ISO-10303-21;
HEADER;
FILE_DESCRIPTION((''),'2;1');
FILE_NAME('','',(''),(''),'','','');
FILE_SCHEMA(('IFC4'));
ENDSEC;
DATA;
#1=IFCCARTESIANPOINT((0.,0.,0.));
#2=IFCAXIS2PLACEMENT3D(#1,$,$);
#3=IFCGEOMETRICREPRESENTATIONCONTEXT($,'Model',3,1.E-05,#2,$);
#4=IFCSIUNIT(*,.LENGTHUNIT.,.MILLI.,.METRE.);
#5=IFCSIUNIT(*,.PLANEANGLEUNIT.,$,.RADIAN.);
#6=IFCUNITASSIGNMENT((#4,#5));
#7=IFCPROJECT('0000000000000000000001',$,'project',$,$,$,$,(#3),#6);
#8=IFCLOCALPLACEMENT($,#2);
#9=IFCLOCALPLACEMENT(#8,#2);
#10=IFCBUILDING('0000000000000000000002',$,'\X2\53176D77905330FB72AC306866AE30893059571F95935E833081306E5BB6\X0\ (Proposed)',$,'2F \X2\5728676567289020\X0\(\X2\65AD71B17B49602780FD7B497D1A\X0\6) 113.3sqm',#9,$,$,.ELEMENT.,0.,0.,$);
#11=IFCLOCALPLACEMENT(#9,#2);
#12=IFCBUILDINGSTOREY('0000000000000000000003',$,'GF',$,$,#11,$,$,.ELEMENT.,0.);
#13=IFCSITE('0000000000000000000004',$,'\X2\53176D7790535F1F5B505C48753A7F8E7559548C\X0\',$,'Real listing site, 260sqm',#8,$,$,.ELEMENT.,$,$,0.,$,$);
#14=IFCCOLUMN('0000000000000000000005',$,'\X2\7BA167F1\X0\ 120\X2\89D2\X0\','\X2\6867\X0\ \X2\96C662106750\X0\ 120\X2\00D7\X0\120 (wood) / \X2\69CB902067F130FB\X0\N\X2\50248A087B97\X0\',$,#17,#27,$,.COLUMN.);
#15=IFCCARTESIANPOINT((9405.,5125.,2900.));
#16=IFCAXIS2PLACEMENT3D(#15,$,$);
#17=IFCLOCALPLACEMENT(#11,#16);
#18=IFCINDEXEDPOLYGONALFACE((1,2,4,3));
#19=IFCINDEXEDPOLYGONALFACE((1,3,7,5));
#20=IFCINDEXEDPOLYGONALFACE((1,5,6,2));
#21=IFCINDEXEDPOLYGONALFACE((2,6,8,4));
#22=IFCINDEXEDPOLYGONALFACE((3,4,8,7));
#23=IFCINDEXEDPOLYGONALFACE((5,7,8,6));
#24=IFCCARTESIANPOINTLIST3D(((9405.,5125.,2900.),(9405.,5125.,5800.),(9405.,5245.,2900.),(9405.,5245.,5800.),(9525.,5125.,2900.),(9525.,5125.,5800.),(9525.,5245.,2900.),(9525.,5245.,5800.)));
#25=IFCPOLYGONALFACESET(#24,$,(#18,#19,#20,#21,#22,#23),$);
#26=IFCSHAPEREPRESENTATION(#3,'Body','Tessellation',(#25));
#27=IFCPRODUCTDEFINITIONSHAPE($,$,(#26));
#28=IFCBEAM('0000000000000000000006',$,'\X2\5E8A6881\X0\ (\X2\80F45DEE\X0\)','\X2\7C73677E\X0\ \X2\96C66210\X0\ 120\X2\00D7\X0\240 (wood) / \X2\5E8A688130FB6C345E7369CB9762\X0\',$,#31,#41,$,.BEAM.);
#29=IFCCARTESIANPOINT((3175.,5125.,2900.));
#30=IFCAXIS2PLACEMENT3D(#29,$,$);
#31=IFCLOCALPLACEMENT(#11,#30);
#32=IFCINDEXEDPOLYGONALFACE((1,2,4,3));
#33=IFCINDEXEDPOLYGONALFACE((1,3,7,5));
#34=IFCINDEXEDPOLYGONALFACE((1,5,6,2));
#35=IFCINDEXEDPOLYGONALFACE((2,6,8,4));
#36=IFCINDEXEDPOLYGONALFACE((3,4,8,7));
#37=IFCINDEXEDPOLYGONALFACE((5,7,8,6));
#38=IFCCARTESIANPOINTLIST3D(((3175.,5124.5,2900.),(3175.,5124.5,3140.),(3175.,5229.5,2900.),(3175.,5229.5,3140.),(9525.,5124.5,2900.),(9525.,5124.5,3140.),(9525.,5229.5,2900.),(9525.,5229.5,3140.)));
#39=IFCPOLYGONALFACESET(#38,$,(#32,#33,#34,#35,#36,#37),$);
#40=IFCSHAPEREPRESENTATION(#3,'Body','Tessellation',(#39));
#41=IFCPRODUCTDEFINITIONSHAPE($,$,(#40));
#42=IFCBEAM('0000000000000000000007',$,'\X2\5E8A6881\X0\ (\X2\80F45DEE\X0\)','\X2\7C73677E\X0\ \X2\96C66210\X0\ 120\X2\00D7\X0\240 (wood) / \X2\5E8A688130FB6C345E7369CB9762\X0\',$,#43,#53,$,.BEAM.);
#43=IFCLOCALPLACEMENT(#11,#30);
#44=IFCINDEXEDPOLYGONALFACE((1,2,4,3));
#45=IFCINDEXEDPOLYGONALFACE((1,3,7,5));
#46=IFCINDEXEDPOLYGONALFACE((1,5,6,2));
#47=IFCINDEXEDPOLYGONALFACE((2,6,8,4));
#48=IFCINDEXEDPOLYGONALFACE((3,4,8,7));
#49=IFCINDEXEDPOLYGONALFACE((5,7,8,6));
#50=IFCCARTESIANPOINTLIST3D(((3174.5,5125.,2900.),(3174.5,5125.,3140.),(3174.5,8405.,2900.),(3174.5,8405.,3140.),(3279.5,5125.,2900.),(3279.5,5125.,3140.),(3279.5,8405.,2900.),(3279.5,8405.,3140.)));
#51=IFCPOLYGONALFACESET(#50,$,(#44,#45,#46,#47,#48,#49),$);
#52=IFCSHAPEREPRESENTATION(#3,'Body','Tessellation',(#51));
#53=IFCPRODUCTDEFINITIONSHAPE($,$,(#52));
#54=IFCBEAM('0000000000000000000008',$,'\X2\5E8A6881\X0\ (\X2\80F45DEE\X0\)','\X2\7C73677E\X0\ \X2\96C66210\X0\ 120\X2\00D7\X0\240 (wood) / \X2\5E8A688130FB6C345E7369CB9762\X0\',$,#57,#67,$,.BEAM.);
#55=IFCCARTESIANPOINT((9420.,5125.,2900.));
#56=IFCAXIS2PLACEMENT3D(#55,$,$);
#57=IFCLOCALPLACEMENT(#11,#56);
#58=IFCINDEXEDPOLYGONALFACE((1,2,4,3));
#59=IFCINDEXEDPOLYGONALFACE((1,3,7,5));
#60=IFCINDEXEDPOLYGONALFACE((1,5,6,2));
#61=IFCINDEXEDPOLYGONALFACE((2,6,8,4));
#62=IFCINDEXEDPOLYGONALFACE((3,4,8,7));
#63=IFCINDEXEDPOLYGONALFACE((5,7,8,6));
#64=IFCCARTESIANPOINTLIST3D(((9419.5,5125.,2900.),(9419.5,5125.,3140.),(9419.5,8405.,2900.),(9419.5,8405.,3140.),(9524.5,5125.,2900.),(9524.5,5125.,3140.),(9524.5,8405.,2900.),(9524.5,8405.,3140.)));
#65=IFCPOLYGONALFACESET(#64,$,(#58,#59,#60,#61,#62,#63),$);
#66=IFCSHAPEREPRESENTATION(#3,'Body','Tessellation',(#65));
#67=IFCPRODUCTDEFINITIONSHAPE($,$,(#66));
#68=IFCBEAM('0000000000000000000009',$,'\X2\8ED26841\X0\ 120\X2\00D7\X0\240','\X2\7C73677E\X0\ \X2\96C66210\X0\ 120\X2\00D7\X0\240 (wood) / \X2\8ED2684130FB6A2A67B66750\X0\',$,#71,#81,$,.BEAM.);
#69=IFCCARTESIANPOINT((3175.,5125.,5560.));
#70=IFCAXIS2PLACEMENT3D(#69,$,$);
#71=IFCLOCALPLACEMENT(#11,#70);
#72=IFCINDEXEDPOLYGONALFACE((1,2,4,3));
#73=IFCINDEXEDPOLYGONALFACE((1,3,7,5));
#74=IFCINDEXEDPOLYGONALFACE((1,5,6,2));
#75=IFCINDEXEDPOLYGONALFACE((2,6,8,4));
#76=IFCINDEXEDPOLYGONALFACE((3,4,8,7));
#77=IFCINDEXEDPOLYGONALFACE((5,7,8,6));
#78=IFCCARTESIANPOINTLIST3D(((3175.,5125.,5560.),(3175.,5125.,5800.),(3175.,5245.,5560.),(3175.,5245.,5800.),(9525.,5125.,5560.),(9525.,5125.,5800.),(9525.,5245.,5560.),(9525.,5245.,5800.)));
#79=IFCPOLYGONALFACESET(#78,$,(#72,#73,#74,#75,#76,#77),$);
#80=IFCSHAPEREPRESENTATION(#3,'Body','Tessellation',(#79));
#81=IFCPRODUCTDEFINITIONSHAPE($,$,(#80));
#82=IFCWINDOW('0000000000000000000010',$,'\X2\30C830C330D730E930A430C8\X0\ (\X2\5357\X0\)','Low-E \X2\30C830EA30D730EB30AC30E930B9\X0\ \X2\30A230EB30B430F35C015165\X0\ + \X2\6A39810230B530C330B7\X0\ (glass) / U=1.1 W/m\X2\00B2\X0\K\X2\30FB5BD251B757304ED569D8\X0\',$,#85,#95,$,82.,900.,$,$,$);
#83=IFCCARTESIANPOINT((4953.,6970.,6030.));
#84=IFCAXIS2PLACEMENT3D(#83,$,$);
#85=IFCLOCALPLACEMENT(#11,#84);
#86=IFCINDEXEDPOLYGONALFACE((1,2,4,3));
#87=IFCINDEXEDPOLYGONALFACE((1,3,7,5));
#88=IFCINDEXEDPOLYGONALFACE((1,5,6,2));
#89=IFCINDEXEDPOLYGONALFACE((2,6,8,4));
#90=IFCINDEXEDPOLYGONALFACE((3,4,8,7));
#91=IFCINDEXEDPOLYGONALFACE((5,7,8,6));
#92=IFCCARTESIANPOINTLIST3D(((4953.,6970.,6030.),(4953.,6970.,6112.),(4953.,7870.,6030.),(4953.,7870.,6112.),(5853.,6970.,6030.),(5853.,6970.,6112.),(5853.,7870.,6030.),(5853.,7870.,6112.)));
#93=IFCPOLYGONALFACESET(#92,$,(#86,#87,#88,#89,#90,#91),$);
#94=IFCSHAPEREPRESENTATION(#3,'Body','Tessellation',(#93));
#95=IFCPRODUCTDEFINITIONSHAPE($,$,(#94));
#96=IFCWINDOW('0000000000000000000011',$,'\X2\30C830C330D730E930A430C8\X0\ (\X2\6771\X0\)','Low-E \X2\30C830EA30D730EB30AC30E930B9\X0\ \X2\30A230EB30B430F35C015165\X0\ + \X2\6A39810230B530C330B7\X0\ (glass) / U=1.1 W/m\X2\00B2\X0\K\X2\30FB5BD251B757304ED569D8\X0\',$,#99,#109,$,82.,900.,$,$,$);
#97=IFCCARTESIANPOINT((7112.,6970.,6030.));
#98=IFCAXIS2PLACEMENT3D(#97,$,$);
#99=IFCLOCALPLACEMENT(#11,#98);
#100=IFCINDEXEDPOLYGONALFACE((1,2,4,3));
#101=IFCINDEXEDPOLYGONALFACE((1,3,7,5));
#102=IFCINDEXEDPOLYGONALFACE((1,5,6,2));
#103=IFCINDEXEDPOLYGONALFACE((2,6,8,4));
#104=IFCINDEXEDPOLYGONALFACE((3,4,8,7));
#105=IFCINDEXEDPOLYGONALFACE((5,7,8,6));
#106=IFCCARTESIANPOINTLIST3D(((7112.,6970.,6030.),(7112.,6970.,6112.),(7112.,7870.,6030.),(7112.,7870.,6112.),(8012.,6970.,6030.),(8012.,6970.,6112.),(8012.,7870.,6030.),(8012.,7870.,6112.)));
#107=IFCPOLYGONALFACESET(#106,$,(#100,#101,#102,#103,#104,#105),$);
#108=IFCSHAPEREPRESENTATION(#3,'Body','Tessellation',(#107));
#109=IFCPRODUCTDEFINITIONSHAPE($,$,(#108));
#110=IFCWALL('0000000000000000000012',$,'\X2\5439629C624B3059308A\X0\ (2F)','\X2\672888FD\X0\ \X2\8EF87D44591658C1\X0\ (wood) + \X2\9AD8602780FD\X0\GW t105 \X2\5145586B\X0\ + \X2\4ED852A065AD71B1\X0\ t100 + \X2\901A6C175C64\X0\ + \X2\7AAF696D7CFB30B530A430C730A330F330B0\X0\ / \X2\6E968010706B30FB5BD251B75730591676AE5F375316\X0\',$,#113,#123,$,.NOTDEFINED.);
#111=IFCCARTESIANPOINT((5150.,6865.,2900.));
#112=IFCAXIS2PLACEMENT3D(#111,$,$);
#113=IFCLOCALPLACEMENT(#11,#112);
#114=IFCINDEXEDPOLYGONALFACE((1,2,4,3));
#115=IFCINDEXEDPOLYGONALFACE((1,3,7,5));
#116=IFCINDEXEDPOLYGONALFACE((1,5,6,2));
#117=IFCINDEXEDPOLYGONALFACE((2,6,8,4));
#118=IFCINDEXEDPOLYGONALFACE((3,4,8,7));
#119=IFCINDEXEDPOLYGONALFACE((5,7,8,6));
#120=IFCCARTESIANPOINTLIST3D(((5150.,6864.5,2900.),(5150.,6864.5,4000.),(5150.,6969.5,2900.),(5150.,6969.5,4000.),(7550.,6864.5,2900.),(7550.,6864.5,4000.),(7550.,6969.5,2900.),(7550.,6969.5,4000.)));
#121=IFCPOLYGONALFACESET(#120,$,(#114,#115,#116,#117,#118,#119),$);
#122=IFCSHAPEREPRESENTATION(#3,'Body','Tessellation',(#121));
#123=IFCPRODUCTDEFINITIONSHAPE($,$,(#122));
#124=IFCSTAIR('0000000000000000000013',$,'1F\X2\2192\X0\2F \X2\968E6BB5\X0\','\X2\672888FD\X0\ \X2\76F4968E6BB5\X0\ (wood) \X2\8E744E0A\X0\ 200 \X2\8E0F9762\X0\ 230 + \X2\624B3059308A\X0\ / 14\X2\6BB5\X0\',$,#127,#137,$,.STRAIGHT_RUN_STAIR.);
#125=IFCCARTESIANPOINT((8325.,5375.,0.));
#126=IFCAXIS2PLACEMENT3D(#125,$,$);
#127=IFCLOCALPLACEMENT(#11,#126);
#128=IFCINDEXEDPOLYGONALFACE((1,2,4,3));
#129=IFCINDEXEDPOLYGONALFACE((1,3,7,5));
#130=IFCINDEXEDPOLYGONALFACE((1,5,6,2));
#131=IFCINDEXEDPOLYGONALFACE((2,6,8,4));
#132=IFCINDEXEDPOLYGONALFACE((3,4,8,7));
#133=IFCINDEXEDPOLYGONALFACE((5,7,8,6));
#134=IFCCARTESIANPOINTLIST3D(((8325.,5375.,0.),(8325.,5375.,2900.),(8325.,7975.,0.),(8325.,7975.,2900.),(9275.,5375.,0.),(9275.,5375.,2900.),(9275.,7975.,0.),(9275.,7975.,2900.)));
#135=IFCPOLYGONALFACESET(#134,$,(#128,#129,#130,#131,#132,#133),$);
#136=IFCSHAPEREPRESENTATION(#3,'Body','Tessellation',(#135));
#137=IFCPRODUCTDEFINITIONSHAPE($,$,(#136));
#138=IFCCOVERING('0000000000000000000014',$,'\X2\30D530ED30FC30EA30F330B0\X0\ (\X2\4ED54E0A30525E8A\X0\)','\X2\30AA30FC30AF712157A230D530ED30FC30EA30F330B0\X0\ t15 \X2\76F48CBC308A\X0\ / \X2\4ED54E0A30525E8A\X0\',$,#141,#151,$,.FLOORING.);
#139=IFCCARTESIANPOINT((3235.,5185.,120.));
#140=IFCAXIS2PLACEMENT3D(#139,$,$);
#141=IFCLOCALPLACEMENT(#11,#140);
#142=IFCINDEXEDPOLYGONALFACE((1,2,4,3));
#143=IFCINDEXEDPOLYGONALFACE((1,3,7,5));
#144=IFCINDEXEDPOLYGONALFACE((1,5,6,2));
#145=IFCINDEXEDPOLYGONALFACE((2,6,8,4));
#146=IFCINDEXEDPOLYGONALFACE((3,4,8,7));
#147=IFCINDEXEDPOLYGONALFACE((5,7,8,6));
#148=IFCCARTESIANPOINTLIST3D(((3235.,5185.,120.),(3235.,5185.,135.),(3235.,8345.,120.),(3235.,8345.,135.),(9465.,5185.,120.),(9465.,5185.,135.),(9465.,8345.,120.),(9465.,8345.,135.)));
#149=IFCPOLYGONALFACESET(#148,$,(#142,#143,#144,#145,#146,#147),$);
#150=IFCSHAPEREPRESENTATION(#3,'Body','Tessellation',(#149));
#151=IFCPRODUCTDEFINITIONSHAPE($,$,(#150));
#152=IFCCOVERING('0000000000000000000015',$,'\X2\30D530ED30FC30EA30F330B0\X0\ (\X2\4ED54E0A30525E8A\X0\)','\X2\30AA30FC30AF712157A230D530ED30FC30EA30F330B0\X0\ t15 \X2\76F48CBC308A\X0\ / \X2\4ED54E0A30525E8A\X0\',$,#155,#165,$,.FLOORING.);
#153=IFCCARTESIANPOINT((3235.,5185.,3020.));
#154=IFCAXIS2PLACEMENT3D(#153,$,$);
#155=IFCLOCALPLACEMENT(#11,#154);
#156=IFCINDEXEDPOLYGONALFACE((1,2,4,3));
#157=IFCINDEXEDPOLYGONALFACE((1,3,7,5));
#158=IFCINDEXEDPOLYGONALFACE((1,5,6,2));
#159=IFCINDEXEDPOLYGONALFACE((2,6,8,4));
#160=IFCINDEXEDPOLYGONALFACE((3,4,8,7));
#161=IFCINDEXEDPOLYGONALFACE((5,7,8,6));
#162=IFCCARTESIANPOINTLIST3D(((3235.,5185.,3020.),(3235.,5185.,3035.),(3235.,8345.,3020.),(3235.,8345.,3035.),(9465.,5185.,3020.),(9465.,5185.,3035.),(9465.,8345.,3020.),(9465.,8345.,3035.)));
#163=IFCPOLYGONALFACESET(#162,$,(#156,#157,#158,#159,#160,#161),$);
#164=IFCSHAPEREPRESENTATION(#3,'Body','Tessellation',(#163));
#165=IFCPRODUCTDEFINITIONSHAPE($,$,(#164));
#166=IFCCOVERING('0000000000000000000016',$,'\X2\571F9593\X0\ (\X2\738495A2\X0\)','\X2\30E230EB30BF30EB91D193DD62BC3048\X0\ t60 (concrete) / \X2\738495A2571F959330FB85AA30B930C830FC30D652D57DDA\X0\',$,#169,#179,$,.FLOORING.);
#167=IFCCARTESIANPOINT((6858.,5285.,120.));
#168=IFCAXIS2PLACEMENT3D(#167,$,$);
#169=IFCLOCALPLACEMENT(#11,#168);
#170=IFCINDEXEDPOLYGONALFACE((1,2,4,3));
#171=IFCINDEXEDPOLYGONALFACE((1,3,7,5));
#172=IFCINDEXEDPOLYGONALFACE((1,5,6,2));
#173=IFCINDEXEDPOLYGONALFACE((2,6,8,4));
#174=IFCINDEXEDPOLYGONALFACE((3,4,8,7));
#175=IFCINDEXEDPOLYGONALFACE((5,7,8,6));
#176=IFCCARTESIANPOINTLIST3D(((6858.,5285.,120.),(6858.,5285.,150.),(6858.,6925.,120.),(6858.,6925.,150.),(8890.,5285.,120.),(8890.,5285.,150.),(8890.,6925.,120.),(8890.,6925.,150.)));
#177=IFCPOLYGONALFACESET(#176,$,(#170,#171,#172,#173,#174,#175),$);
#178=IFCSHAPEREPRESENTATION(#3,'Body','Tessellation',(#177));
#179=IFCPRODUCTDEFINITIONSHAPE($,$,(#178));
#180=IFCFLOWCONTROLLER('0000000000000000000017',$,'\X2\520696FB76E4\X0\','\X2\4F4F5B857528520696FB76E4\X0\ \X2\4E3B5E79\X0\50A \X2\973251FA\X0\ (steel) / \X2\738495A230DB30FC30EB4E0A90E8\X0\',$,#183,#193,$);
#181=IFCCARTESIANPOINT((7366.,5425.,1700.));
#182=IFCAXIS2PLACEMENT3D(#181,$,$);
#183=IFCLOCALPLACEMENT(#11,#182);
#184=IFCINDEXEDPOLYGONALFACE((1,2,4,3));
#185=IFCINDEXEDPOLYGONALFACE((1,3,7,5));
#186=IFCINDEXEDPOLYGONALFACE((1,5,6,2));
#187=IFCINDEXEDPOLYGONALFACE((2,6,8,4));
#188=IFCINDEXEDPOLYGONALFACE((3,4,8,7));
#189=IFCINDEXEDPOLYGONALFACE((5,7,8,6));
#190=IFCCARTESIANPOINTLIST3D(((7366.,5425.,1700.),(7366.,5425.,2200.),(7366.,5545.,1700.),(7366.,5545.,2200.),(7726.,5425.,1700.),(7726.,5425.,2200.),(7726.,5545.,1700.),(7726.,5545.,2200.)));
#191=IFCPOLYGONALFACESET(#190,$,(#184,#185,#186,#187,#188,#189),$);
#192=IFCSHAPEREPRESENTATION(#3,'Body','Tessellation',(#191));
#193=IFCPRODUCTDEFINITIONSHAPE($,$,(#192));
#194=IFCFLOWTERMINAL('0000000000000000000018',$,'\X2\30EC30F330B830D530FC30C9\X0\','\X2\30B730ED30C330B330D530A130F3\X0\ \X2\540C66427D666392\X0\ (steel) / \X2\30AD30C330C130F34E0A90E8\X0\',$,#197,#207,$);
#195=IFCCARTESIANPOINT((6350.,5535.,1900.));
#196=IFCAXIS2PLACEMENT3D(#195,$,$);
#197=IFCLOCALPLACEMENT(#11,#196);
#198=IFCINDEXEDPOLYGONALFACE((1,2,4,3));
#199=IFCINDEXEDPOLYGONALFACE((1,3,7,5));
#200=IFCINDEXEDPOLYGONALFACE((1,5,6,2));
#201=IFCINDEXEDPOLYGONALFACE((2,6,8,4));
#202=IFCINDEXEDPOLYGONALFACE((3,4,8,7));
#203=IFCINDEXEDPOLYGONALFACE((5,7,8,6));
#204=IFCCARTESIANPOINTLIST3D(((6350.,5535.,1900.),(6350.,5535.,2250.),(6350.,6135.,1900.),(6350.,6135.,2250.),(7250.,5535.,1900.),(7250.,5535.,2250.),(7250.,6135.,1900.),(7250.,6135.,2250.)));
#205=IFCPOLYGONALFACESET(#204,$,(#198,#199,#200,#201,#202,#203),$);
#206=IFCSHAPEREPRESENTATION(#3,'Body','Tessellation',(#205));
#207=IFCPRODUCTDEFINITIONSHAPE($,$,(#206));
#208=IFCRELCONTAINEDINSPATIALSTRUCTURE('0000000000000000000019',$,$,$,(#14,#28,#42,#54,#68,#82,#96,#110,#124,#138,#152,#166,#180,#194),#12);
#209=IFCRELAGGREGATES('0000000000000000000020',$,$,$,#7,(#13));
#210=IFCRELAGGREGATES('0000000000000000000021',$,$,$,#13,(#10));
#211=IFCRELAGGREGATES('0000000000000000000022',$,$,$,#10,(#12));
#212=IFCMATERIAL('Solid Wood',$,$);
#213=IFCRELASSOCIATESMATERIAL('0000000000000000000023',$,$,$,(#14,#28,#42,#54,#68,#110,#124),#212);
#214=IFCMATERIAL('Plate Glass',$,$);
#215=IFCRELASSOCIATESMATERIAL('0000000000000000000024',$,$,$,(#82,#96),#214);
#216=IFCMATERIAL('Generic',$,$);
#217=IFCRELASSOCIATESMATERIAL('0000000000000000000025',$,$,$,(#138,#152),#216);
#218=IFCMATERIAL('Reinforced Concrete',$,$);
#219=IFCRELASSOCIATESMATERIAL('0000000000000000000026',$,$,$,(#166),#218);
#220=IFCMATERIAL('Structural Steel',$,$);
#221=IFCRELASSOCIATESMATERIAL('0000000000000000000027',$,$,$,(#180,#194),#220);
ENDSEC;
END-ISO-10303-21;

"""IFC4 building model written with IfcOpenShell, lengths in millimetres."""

from ifc_helpers import new_model, si_unit, frame, frame_2d, origin, place, context, project, spatial, rectangle, extrude, material, element, save


model = new_model("IFC4")

# Units and contexts
model_context = context("Model", 3, precision=1e-05, world=origin())
ifc_project = project(units=[si_unit("LENGTHUNIT", "METRE", prefix="MILLI"), si_unit("PLANEANGLEUNIT", "RADIAN")], contexts=[model_context])

# Site, building, storey
site_placement = place(None, origin())
site = spatial("IfcSite", under=ifc_project, at=site_placement, Name="北海道弟子屈町美留和", ObjectType="Real listing site, 260sqm", CompositionType="ELEMENT", RefElevation=0.0)
building_placement = place(site_placement, origin())
building = spatial("IfcBuilding", under=site, at=building_placement, Name="北海道・犬と暮らす土間広めの家 (Proposed)", ObjectType="2F 在来木造(断熱等性能等級6) 113.3sqm", CompositionType="ELEMENT", ElevationOfRefHeight=0.0, ElevationOfTerrain=0.0)
storey_placement = place(building_placement, origin())
storey = spatial("IfcBuildingStorey", under=building, at=storey_placement, Name="GF", CompositionType="ELEMENT", Elevation=0.0)

# Column
ifc_material_1 = material(Name="Solid Wood")
column_1_placement = place(storey_placement, frame((9405.0, 5125.0, 2900.0)))
element("IfcColumn", 1, at=column_1_placement, inside=storey, material=ifc_material_1, Name="管柱 120角", Description="桧 集成材 120×120 (wood) / 構造柱・N値計算", PredefinedType="COLUMN", context=model_context, shape_type="SweptSolid", body=[
    extrude(rectangle(XDim=120.0, YDim=120.0, at=frame_2d((60.0, 60.0))), frame((9405.0, 5125.0, 2900.0)), (0.0, 0.0, 1.0), 2900.0),
])

# Beams
beam_1_placement = place(storey_placement, frame((3175.0, 5125.0, 2900.0)))
element("IfcBeam", 2, at=beam_1_placement, inside=storey, material=ifc_material_1, Name="床梁 (胴差)", Description="米松 集成 120×240 (wood) / 床梁・水平構面", PredefinedType="BEAM", context=model_context, shape_type="SweptSolid", body=[
    extrude(rectangle(XDim=6350.0, YDim=105.0, at=frame_2d((3175.0, 52.0))), frame((3175.0, 5125.0, 2900.0)), (0.0, 0.0, 1.0), 240.0),
])
beam_2_placement = place(storey_placement, frame((3175.0, 5125.0, 2900.0)))
element("IfcBeam", 3, at=beam_2_placement, inside=storey, material=ifc_material_1, Name="床梁 (胴差)", Description="米松 集成 120×240 (wood) / 床梁・水平構面", PredefinedType="BEAM", context=model_context, shape_type="SweptSolid", body=[
    extrude(rectangle(XDim=105.0, YDim=3280.0, at=frame_2d((52.0, 1640.0))), frame((3175.0, 5125.0, 2900.0)), (0.0, 0.0, 1.0), 240.0),
])
beam_3_placement = place(storey_placement, frame((9420.0, 5125.0, 2900.0)))
element("IfcBeam", 4, at=beam_3_placement, inside=storey, material=ifc_material_1, Name="床梁 (胴差)", Description="米松 集成 120×240 (wood) / 床梁・水平構面", PredefinedType="BEAM", context=model_context, shape_type="SweptSolid", body=[
    extrude(rectangle(XDim=105.0, YDim=3280.0, at=frame_2d((52.0, 1640.0))), frame((9420.0, 5125.0, 2900.0)), (0.0, 0.0, 1.0), 240.0),
])
beam_4_placement = place(storey_placement, frame((3175.0, 5125.0, 5560.0)))
element("IfcBeam", 5, at=beam_4_placement, inside=storey, material=ifc_material_1, Name="軒桁 120×240", Description="米松 集成 120×240 (wood) / 軒桁・横架材", PredefinedType="BEAM", context=model_context, shape_type="SweptSolid", body=[
    extrude(rectangle(XDim=6350.0, YDim=120.0, at=frame_2d((3175.0, 60.0))), frame((3175.0, 5125.0, 5560.0)), (0.0, 0.0, 1.0), 240.0),
])

# Windows
ifc_material_2 = material(Name="Plate Glass")
window_1_placement = place(storey_placement, frame((4953.0, 6970.0, 6030.0)))
element("IfcWindow", 6, at=window_1_placement, inside=storey, material=ifc_material_2, Name="トップライト (南)", Description="Low-E トリプルガラス アルゴン封入 + 樹脂サッシ (glass) / U=1.1 W/m²K・寒冷地仕様", OverallHeight=82.0, OverallWidth=900.0, context=model_context, shape_type="SweptSolid", body=[
    extrude(rectangle(XDim=900.0, YDim=900.0, at=frame_2d((450.0, 450.0))), frame((4953.0, 6970.0, 6030.0)), (0.0, 0.0, 1.0), 82.0),
])
window_2_placement = place(storey_placement, frame((7112.0, 6970.0, 6030.0)))
element("IfcWindow", 7, at=window_2_placement, inside=storey, material=ifc_material_2, Name="トップライト (東)", Description="Low-E トリプルガラス アルゴン封入 + 樹脂サッシ (glass) / U=1.1 W/m²K・寒冷地仕様", OverallHeight=82.0, OverallWidth=900.0, context=model_context, shape_type="SweptSolid", body=[
    extrude(rectangle(XDim=900.0, YDim=900.0, at=frame_2d((450.0, 450.0))), frame((7112.0, 6970.0, 6030.0)), (0.0, 0.0, 1.0), 82.0),
])

# Wall
wall_1_placement = place(storey_placement, frame((5150.0, 6865.0, 2900.0)))
element("IfcWall", 8, at=wall_1_placement, inside=storey, material=ifc_material_1, Name="吹抜手すり (2F)", Description="木製 軸組外壁 (wood) + 高性能GW t105 充填 + 付加断熱 t100 + 通気層 + 窯業系サイディング / 準耐火・寒冷地外皮強化", PredefinedType="NOTDEFINED", context=model_context, shape_type="SweptSolid", body=[
    extrude(rectangle(XDim=2400.0, YDim=105.0, at=frame_2d((1200.0, 52.0))), frame((5150.0, 6865.0, 2900.0)), (0.0, 0.0, 1.0), 1100.0),
])

# Stair
stair_placement = place(storey_placement, frame((8325.0, 5375.0, 0.0)))
element("IfcStair", 9, at=stair_placement, inside=storey, material=ifc_material_1, Name="1F→2F 階段", Description="木製 直階段 (wood) 蹴上 200 踏面 230 + 手すり / 14段", PredefinedType="STRAIGHT_RUN_STAIR", context=model_context, shape_type="SweptSolid", body=[
    extrude(rectangle(XDim=950.0, YDim=2600.0, at=frame_2d((475.0, 1300.0))), frame((8325.0, 5375.0, 0.0)), (0.0, 0.0, 1.0), 2900.0),
])

# Coverings
ifc_material_3 = material(Name="Generic")
covering_1_placement = place(storey_placement, frame((3235.0, 5185.0, 120.0)))
element("IfcCovering", 10, at=covering_1_placement, inside=storey, material=ifc_material_3, Name="フローリング (仕上げ床)", Description="オーク無垢フローリング t15 直貼り / 仕上げ床", PredefinedType="FLOORING", context=model_context, shape_type="SweptSolid", body=[
    extrude(rectangle(XDim=6230.0, YDim=3160.0, at=frame_2d((3115.0, 1580.0))), frame((3235.0, 5185.0, 120.0)), (0.0, 0.0, 1.0), 15.0),
])
covering_2_placement = place(storey_placement, frame((3235.0, 5185.0, 3020.0)))
element("IfcCovering", 11, at=covering_2_placement, inside=storey, material=ifc_material_3, Name="フローリング (仕上げ床)", Description="オーク無垢フローリング t15 直貼り / 仕上げ床", PredefinedType="FLOORING", context=model_context, shape_type="SweptSolid", body=[
    extrude(rectangle(XDim=6230.0, YDim=3160.0, at=frame_2d((3115.0, 1580.0))), frame((3235.0, 5185.0, 3020.0)), (0.0, 0.0, 1.0), 15.0),
])
ifc_material_4 = material(Name="Reinforced Concrete")
covering_3_placement = place(storey_placement, frame((6858.0, 5285.0, 120.0)))
element("IfcCovering", 12, at=covering_3_placement, inside=storey, material=ifc_material_4, Name="土間 (玄関)", Description="モルタル金鏝押え t60 (concrete) / 玄関土間・薪ストーブ動線", PredefinedType="FLOORING", context=model_context, shape_type="SweptSolid", body=[
    extrude(rectangle(XDim=2032.0, YDim=1640.0, at=frame_2d((1016.0, 820.0))), frame((6858.0, 5285.0, 120.0)), (0.0, 0.0, 1.0), 30.0),
])

# Flow controller
ifc_material_5 = material(Name="Structural Steel")
flow_controller_placement = place(storey_placement, frame((7366.0, 5425.0, 1700.0)))
element("IfcFlowController", 13, at=flow_controller_placement, inside=storey, material=ifc_material_5, Name="分電盤", Description="住宅用分電盤 主幹50A 露出 (steel) / 玄関ホール上部", context=model_context, shape_type="SweptSolid", body=[
    extrude(rectangle(XDim=360.0, YDim=120.0, at=frame_2d((180.0, 60.0))), frame((7366.0, 5425.0, 1700.0)), (0.0, 0.0, 1.0), 500.0),
])

# Flow terminal
flow_terminal_1_placement = place(storey_placement, frame((6350.0, 5535.0, 1900.0)))
element("IfcFlowTerminal", 14, at=flow_terminal_1_placement, inside=storey, material=ifc_material_5, Name="レンジフード", Description="シロッコファン 同時給排 (steel) / キッチン上部", context=model_context, shape_type="SweptSolid", body=[
    extrude(rectangle(XDim=900.0, YDim=600.0, at=frame_2d((450.0, 300.0))), frame((6350.0, 5535.0, 1900.0)), (0.0, 0.0, 1.0), 350.0),
])

save(model, "model.ifc")
